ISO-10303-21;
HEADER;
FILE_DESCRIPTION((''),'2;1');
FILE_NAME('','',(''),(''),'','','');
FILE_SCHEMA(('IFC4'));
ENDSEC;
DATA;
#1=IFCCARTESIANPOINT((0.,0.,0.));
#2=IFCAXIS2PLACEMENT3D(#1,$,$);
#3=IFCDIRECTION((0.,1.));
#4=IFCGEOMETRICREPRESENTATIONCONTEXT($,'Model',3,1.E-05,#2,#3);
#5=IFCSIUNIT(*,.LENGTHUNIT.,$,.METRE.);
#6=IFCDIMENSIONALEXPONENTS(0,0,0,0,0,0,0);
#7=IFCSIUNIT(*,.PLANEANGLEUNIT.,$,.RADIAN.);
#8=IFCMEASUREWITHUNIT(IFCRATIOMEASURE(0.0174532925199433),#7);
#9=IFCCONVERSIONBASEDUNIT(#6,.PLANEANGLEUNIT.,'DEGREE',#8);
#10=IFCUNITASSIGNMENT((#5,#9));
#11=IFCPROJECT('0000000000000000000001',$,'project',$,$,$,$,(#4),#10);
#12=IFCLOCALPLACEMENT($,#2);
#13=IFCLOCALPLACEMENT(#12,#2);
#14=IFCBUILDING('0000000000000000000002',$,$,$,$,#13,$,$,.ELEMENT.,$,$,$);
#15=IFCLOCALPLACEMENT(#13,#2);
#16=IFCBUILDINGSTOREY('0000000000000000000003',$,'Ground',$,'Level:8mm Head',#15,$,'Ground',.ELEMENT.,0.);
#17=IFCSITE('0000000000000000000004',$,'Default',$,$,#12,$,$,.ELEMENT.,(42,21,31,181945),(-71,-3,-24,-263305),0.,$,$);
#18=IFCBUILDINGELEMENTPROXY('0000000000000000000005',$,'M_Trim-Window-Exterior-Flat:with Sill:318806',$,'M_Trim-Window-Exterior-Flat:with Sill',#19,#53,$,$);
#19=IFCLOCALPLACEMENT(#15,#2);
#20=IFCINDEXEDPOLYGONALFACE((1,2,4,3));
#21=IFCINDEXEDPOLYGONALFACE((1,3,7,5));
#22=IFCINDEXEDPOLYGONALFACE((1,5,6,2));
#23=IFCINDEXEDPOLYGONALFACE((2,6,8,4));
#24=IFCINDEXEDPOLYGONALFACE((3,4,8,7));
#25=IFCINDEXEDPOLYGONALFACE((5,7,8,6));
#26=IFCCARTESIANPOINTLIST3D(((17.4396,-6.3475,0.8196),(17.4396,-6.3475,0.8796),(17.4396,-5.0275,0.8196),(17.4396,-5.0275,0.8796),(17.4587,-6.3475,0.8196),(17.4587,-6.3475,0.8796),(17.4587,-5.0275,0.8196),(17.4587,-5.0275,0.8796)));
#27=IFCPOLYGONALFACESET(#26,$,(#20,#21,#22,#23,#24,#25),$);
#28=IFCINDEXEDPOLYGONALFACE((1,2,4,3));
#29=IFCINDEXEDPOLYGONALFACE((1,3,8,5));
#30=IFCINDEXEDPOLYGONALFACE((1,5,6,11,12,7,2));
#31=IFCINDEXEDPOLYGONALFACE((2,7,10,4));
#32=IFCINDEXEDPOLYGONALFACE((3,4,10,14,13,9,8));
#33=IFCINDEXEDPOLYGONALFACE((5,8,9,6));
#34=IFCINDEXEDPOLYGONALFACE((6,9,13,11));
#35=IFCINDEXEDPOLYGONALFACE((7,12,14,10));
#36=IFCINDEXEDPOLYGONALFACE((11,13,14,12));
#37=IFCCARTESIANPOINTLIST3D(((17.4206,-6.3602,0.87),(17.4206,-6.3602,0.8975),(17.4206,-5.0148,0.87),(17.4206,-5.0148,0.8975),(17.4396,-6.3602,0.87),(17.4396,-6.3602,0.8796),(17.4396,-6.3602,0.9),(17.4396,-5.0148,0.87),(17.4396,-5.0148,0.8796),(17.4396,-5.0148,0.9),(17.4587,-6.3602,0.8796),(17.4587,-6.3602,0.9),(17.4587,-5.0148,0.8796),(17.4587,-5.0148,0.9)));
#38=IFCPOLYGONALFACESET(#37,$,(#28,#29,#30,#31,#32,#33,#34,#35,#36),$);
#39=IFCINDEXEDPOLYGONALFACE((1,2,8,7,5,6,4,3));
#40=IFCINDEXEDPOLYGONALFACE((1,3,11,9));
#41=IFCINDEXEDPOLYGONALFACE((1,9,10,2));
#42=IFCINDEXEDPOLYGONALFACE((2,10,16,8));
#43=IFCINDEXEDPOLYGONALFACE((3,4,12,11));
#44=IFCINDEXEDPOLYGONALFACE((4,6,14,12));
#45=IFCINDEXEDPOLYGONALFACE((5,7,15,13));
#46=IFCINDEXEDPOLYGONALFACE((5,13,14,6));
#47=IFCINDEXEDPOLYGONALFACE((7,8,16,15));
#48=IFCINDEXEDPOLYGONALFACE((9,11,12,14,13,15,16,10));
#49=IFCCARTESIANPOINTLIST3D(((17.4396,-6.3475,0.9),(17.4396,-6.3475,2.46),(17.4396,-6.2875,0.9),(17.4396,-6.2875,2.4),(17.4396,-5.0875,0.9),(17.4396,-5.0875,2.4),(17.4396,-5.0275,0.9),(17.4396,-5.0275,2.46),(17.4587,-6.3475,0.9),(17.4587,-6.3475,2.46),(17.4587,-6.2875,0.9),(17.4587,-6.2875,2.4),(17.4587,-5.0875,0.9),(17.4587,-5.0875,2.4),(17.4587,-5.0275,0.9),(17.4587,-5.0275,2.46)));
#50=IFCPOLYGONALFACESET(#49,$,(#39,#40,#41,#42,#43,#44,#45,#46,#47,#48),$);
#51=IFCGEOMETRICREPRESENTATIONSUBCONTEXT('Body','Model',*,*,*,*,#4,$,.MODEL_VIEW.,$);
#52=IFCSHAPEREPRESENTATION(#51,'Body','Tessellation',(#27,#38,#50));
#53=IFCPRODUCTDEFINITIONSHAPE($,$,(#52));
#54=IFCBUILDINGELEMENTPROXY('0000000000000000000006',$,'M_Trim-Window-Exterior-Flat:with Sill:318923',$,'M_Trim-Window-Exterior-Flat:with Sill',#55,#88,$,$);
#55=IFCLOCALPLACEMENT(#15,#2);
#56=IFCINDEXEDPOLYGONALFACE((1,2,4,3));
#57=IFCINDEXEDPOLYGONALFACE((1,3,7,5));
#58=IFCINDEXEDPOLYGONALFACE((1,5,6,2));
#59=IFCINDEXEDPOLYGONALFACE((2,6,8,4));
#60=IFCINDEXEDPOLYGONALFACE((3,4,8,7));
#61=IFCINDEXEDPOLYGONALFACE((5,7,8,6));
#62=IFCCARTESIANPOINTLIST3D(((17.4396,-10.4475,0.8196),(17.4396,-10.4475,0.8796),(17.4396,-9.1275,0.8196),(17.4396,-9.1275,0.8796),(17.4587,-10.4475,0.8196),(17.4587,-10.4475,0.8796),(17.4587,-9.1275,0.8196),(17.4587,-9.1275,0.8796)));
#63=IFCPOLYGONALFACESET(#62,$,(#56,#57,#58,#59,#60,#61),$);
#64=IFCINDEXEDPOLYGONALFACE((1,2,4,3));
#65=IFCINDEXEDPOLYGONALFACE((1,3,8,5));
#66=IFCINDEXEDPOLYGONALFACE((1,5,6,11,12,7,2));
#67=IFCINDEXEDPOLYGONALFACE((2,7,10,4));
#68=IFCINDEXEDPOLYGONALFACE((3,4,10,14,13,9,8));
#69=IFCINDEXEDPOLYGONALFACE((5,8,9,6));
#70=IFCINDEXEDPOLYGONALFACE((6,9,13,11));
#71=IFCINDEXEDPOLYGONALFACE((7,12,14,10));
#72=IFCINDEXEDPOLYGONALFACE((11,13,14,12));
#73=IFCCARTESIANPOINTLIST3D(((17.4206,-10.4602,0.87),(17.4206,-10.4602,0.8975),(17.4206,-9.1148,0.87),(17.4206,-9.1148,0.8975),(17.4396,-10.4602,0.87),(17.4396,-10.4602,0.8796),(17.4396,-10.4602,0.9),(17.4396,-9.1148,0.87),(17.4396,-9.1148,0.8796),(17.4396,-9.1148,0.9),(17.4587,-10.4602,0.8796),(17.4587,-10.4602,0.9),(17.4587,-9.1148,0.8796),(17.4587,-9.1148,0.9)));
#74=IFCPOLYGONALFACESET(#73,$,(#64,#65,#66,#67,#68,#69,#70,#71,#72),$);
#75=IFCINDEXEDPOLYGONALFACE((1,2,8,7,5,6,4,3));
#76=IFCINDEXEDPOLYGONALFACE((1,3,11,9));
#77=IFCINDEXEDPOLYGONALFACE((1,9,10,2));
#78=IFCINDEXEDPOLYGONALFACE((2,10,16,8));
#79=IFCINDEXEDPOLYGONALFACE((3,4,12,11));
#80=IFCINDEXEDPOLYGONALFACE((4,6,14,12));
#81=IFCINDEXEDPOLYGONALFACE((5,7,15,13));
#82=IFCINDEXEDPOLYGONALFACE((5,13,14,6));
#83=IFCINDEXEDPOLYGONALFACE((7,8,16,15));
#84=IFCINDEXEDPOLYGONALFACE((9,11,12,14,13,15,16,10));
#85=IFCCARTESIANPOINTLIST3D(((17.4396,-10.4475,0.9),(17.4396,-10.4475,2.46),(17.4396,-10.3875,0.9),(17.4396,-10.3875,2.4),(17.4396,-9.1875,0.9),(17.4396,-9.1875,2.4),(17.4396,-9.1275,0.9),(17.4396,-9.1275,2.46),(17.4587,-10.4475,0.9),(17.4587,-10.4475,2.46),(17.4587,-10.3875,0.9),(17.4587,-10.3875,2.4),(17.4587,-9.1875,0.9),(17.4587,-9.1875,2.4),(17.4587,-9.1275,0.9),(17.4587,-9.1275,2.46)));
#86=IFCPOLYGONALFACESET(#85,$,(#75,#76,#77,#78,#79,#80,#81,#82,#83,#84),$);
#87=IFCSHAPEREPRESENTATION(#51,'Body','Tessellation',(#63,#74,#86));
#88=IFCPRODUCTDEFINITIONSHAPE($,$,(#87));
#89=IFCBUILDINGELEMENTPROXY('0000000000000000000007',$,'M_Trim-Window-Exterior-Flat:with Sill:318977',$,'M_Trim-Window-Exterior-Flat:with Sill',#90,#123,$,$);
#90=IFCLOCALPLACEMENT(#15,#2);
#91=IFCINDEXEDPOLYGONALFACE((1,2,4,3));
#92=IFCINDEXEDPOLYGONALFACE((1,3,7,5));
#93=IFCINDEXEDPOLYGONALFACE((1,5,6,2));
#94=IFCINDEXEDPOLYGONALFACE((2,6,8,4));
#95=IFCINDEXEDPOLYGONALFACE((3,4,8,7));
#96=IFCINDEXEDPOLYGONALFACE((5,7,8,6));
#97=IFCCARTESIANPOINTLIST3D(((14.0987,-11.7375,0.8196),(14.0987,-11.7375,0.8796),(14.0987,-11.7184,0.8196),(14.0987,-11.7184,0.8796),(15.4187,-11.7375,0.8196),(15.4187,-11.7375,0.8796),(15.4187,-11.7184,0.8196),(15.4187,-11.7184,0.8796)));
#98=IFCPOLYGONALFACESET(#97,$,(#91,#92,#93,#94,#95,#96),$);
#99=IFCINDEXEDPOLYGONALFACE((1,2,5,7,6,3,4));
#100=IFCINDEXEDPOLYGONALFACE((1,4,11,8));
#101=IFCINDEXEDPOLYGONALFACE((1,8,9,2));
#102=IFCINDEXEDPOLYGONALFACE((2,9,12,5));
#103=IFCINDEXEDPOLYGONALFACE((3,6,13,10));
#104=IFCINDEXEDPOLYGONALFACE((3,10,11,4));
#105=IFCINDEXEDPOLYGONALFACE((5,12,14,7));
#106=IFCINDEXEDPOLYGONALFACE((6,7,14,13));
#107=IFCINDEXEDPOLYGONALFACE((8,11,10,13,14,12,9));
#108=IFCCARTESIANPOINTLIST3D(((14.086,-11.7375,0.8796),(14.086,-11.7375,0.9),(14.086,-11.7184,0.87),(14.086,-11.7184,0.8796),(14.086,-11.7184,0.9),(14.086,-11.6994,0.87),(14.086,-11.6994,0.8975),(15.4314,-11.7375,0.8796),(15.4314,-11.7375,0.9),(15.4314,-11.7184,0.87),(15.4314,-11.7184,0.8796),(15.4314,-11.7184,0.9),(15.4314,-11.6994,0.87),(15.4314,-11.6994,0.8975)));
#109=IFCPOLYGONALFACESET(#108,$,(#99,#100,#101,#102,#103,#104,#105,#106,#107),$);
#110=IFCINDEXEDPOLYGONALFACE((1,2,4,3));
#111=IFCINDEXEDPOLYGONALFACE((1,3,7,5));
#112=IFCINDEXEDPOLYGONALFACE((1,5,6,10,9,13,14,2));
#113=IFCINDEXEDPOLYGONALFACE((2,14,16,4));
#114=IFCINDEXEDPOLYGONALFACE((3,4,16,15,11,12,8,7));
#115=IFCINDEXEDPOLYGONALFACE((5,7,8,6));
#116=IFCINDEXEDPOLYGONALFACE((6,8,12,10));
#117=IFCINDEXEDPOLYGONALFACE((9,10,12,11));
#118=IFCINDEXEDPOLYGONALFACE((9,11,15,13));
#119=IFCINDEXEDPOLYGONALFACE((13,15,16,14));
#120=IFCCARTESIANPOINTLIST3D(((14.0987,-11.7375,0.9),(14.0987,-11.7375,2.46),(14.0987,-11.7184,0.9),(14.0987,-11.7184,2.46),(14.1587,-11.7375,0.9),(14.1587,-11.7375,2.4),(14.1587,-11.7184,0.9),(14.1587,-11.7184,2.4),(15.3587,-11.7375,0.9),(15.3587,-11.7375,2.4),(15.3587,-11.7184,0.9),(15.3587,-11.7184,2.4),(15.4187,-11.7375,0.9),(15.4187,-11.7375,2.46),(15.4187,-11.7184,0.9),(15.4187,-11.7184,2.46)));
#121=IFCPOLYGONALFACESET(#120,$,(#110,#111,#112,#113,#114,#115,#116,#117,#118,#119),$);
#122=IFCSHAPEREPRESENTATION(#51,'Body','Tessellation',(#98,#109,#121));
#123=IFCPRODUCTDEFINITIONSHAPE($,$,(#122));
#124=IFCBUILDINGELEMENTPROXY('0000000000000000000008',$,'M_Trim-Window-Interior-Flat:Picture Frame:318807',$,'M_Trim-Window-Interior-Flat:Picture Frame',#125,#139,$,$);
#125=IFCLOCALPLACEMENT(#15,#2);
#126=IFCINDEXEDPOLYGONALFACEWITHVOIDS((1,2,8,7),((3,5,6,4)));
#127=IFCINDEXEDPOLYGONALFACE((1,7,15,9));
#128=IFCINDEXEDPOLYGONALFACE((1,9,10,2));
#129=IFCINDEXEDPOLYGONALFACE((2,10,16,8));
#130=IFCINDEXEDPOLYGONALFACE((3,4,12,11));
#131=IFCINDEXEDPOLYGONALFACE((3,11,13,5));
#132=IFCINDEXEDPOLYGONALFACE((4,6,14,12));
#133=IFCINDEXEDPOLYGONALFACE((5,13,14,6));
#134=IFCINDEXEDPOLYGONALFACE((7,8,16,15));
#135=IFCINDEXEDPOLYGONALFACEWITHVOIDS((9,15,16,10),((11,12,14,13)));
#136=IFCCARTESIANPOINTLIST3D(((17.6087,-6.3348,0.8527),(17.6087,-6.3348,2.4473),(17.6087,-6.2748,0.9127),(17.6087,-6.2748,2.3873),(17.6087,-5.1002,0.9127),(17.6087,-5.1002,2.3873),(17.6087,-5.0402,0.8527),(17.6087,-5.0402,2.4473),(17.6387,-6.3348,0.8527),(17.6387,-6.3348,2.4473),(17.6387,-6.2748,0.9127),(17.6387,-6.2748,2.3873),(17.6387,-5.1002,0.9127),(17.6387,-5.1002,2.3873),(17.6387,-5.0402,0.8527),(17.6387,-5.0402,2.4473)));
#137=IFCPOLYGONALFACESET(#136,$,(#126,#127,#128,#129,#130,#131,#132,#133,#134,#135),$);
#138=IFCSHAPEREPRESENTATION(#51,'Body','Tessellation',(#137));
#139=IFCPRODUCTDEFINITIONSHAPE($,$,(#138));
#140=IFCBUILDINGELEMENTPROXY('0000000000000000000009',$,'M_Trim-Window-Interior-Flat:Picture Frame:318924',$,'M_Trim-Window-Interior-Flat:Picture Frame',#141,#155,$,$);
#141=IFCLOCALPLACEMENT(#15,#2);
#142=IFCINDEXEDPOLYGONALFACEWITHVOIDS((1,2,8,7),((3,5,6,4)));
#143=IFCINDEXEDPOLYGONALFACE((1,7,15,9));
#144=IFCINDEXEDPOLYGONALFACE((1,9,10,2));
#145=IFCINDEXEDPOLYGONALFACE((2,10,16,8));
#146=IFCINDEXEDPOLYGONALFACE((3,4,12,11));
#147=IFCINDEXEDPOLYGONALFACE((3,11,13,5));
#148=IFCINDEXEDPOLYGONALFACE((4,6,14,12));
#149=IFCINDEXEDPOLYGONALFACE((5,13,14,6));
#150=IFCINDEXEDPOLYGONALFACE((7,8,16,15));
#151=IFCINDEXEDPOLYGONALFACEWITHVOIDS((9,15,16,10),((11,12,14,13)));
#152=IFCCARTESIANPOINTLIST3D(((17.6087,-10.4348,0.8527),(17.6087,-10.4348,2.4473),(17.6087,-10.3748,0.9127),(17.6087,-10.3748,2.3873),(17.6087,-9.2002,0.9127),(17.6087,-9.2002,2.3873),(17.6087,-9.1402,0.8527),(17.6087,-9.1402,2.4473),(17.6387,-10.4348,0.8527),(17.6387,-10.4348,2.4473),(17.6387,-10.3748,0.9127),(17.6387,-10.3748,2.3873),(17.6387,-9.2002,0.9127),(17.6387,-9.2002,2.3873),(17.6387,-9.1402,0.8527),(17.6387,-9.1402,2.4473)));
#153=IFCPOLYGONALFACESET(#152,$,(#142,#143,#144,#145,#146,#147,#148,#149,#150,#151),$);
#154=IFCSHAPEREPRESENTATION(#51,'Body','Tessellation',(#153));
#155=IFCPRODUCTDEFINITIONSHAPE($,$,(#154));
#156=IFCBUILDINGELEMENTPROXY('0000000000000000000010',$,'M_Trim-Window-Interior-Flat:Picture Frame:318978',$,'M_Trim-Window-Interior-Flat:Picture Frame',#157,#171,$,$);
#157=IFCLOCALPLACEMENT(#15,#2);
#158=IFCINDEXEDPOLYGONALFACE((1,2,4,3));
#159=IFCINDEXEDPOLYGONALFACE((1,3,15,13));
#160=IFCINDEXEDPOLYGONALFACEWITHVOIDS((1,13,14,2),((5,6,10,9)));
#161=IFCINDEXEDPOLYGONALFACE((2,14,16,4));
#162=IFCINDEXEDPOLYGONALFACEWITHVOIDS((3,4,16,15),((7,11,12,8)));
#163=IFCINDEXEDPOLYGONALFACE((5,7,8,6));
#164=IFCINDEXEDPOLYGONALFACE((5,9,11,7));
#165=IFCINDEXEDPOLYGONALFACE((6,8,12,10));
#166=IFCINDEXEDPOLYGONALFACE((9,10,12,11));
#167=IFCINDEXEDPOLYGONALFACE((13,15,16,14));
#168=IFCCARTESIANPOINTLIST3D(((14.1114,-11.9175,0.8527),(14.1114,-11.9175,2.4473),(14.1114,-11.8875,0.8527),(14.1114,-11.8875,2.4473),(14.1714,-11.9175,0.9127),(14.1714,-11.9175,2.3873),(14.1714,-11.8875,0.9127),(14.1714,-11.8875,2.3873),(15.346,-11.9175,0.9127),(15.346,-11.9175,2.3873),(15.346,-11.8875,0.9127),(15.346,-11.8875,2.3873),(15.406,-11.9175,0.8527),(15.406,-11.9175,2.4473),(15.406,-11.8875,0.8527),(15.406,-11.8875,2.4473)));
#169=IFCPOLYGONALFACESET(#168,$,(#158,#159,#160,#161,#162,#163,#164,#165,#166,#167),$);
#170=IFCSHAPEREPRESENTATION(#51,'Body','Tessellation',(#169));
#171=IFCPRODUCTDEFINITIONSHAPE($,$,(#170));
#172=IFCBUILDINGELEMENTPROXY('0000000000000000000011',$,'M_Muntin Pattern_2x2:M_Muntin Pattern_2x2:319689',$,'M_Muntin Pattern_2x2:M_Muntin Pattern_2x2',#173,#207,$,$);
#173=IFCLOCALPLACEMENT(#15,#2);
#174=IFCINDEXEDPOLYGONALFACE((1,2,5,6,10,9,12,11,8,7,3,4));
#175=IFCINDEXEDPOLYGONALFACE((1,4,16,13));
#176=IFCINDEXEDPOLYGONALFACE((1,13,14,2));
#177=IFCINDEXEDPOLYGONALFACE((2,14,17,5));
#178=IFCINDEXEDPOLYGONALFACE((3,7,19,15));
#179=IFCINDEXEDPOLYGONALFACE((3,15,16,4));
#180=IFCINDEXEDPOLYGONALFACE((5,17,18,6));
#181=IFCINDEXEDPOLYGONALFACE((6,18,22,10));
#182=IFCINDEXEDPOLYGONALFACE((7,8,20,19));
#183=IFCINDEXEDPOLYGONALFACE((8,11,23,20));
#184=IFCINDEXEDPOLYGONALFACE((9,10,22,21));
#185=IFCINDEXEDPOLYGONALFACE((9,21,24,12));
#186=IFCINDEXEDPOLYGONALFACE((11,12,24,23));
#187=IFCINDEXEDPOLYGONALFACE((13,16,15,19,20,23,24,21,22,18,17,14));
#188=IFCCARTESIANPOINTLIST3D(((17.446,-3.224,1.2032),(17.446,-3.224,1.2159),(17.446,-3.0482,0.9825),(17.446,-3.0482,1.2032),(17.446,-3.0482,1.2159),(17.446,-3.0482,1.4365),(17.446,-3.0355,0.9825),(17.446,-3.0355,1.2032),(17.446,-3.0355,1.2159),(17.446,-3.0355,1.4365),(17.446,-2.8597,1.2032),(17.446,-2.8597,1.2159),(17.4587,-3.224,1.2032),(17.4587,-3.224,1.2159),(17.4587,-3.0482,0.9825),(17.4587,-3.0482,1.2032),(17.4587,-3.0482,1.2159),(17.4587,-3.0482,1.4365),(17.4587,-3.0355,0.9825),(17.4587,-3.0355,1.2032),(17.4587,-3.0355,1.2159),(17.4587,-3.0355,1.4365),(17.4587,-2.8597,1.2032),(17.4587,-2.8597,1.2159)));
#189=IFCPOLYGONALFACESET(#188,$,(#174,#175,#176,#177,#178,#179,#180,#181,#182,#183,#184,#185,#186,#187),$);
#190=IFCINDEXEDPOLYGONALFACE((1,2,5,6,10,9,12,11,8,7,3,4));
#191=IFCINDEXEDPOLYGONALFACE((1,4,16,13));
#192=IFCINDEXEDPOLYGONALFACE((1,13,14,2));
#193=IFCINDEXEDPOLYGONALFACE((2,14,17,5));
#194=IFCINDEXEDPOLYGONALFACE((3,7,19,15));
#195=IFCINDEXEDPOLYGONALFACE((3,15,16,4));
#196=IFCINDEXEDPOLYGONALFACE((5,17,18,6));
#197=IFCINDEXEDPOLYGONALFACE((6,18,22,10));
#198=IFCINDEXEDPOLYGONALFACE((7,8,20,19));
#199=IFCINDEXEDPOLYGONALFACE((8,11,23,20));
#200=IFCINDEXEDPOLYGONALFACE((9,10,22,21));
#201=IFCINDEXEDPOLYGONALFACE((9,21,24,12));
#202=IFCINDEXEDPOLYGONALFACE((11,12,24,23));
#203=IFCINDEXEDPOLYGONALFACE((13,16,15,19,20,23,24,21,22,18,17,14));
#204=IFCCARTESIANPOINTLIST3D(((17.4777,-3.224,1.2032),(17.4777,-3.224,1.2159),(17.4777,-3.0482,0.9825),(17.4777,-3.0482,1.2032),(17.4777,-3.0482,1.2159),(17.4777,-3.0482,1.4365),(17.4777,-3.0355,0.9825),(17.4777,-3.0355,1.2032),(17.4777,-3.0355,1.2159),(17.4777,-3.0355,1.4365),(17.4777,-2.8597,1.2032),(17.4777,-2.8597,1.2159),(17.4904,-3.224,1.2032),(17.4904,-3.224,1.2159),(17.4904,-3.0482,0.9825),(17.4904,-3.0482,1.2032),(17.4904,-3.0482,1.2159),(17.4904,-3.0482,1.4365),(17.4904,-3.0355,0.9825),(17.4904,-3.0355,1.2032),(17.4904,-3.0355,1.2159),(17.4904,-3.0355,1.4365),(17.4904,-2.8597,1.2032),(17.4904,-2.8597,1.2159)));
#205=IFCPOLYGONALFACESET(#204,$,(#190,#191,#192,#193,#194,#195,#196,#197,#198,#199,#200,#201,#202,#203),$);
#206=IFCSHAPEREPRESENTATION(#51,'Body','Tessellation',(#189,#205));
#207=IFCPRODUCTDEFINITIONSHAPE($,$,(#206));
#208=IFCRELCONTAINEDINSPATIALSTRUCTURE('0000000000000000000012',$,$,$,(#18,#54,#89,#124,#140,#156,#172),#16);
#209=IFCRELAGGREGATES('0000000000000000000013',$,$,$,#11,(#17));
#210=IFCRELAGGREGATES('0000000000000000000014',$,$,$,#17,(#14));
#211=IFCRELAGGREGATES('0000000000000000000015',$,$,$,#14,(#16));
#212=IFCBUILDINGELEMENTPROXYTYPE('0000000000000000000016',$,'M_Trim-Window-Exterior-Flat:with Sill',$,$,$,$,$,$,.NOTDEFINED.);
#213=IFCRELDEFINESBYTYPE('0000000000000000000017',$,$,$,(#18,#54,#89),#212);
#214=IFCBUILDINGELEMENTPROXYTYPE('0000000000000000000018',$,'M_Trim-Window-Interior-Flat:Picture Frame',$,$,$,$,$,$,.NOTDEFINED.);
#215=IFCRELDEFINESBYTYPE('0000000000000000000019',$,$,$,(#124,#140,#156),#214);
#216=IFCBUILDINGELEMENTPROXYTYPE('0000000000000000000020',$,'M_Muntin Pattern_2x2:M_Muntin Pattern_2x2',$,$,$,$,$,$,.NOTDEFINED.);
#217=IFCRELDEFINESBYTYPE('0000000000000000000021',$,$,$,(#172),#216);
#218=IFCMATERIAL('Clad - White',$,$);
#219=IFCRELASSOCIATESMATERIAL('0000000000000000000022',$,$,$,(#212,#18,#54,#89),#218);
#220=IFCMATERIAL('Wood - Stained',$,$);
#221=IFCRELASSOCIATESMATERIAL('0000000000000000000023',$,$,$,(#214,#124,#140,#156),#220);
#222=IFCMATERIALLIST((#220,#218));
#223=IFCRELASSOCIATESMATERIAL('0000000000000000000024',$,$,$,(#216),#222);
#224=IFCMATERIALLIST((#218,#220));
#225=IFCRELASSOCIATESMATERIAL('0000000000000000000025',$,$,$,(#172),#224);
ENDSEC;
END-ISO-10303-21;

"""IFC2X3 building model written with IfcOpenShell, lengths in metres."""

from ifc_helpers import new_model, entity, si_unit, converted_unit, direction, frame, frame_2d, origin, place, context, subcontext, project, spatial, polyline, rectangle, outline, extrude, source, transform, mapped, material, material_list, type_object, type_shapes, element, save


model = new_model("IFC2X3")

# Units and contexts
model_context = context("Model", 3, precision=1e-05, world=origin(), true_north=direction((0.0, 1.0)))
body_context = subcontext(model_context, "Body", "Model", "MODEL_VIEW")
ifc_project = project(units=[si_unit("LENGTHUNIT", "METRE"), converted_unit("PLANEANGLEUNIT", "DEGREE", entity("IfcRatioMeasure", 0.0174532925199433), si_unit("PLANEANGLEUNIT", "RADIAN"), dimensions=[0, 0, 0, 0, 0, 0, 0])], contexts=[model_context])

# Site, building, storey
site_placement = place(None, origin())
site = spatial("IfcSite", under=ifc_project, at=site_placement, Name="Default", CompositionType="ELEMENT", RefLatitude=(42, 21, 31, 181945), RefLongitude=(-71, -3, -24, -263305), RefElevation=0.0)
building_placement = place(site_placement, origin())
building = spatial("IfcBuilding", under=site, at=building_placement, CompositionType="ELEMENT")
storey_placement = place(building_placement, origin())
storey = spatial("IfcBuildingStorey", under=building, at=storey_placement, Name="Ground", ObjectType="Level:8mm Head", LongName="Ground", CompositionType="ELEMENT", Elevation=0.0)

# Building element proxies
ifc_material_1 = material(Name="Clad - White")
ifc_material_2 = material(Name="Wood - Stained")
building_element_proxy_type_1 = type_object("IfcBuildingElementProxyType", Name="M_Trim-Window-Exterior-Flat:with Sill", PredefinedType="NOTDEFINED", material=ifc_material_1)
shared_shape_1 = source(origin(), body_context, "Body", "SweptSolid", [
    extrude(rectangle(XDim=1.32, YDim=0.06, at=frame_2d((0.0, 0.0), x_axis=(1.0, 0.0))), frame((0.0, -1.5504, 0.0), z_axis=(0.0, 0.0, 1.0), x_axis=(-1.0, 0.0, 0.0)), (0.0, 0.0, 1.0), 0.0191),
    extrude(outline(polyline([(-0.019, -0.0152), (0.0, -0.0152), (0.0, -0.0057), (0.019, -0.0057), (0.019, 0.0148), (0.0, 0.0148), (-0.019, 0.0123), (-0.019, -0.0152)])), frame((-0.6727, -1.5148, 0.019), z_axis=(1.0, 0.0, 0.0), x_axis=(0.0, 0.0, -1.0)), (0.0, 0.0, 1.0), 1.3454),
    extrude(outline(polyline([(-0.795, -0.66), (0.765, -0.66), (0.765, -0.6), (-0.735, -0.6), (-0.735, 0.6), (0.765, 0.6), (0.765, 0.66), (-0.795, 0.66), (-0.795, -0.66)])), frame((0.0, -0.735, 0.0), z_axis=(0.0, 0.0, 1.0), x_axis=(0.0, -1.0, 0.0)), (0.0, 0.0, 1.0), 0.0191),
])
type_shapes(building_element_proxy_type_1, [shared_shape_1])
for number, where, z_axis, x_axis, name in (
    (1, (17.4587, -5.6875, 2.4), (-1.0, 0.0, 0.0), (0.0, -1.0, 0.0), "M_Trim-Window-Exterior-Flat:with Sill:318806"),
    (2, (17.4587, -9.7875, 2.4), (-1.0, 0.0, 0.0), (0.0, -1.0, 0.0), "M_Trim-Window-Exterior-Flat:with Sill:318923"),
    (3, (14.7587, -11.7375, 2.4), (0.0, 1.0, 0.0), (-1.0, 0.0, 0.0), "M_Trim-Window-Exterior-Flat:with Sill:318977"),
):
    element("IfcBuildingElementProxy", number, at=place(storey_placement, frame(where, z_axis=z_axis, x_axis=x_axis)), inside=storey, type_object=building_element_proxy_type_1, material=ifc_material_1, Name=name, ObjectType="M_Trim-Window-Exterior-Flat:with Sill", context=body_context, shape_type="MappedRepresentation", body=[
        mapped(shared_shape_1, transform((0.0, 0.0, 0.0), scale=1.0)),
    ])
building_element_proxy_type_2 = type_object("IfcBuildingElementProxyType", Name="M_Trim-Window-Interior-Flat:Picture Frame", PredefinedType="NOTDEFINED", material=ifc_material_2)
shared_shape_2 = source(origin(), body_context, "Body", "SweptSolid", [
    extrude(outline(polyline([(-0.6473, -0.7973), (0.6473, -0.7973), (0.6473, 0.7973), (-0.6473, 0.7973), (-0.6473, -0.7973)]), holes=[polyline([(-0.5873, -0.7373), (-0.5873, 0.7373), (0.5873, 0.7373), (0.5873, -0.7373), (-0.5873, -0.7373)])]), frame((0.0, -0.75, 0.0), z_axis=(0.0, 0.0, 1.0), x_axis=(-1.0, 0.0, 0.0)), (0.0, 0.0, 1.0), 0.03),
])
type_shapes(building_element_proxy_type_2, [shared_shape_2])
for number, where, z_axis, x_axis, name in (
    (4, (17.6087, -5.6875, 2.4), (1.0, 0.0, 0.0), (0.0, 1.0, 0.0), "M_Trim-Window-Interior-Flat:Picture Frame:318807"),
    (5, (17.6087, -9.7875, 2.4), (1.0, 0.0, 0.0), (0.0, 1.0, 0.0), "M_Trim-Window-Interior-Flat:Picture Frame:318924"),
    (6, (14.7587, -11.8875, 2.4), (0.0, -1.0, 0.0), (1.0, 0.0, 0.0), "M_Trim-Window-Interior-Flat:Picture Frame:318978"),
):
    element("IfcBuildingElementProxy", number, at=place(storey_placement, frame(where, z_axis=z_axis, x_axis=x_axis)), inside=storey, type_object=building_element_proxy_type_2, material=ifc_material_2, Name=name, ObjectType="M_Trim-Window-Interior-Flat:Picture Frame", context=body_context, shape_type="MappedRepresentation", body=[
        mapped(shared_shape_2, transform((0.0, 0.0, 0.0), scale=1.0)),
    ])
ifc_material_list_1 = material_list([ifc_material_1, ifc_material_2])
ifc_material_list_2 = material_list([ifc_material_2, ifc_material_1])
building_element_proxy_type_3 = type_object("IfcBuildingElementProxyType", Name="M_Muntin Pattern_2x2:M_Muntin Pattern_2x2", PredefinedType="NOTDEFINED", material=ifc_material_list_2)
shared_shape_3 = source(origin(), body_context, "Body", "SweptSolid", [
    extrude(outline(polyline([(0.0064, -0.0064), (0.227, -0.0064), (0.227, 0.0063), (0.0064, 0.0063), (0.0064, 0.1821), (-0.0063, 0.1821), (-0.0063, 0.0063), (-0.227, 0.0063), (-0.227, -0.0064), (-0.0063, -0.0064), (-0.0063, -0.1821), (0.0064, -0.1821), (0.0064, -0.0064)])), frame((0.0, 0.0095, 0.227), z_axis=(0.0, 1.0, 0.0), x_axis=(0.0, 0.0, 1.0)), (0.0, 0.0, 1.0), 0.0127),
    extrude(outline(polyline([(0.0064, -0.0064), (0.227, -0.0064), (0.227, 0.0063), (0.0064, 0.0063), (0.0064, 0.1821), (-0.0063, 0.1821), (-0.0063, 0.0063), (-0.227, 0.0063), (-0.227, -0.0064), (-0.0063, -0.0064), (-0.0063, -0.1821), (0.0064, -0.1821), (0.0064, -0.0064)])), frame((0.0, -0.0222, 0.227), z_axis=(0.0, 1.0, 0.0), x_axis=(0.0, 0.0, 1.0)), (0.0, 0.0, 1.0), 0.0127),
])
type_shapes(building_element_proxy_type_3, [shared_shape_3])
proxy_1_placement = place(storey_placement, frame((17.4682, -3.0418, 0.9825), z_axis=(0.0, 0.0, 1.0), x_axis=(0.0, 1.0, 0.0)))
element("IfcBuildingElementProxy", 7, at=proxy_1_placement, inside=storey, type_object=building_element_proxy_type_3, material=ifc_material_list_1, Name="M_Muntin Pattern_2x2:M_Muntin Pattern_2x2:319689", ObjectType="M_Muntin Pattern_2x2:M_Muntin Pattern_2x2", context=body_context, shape_type="MappedRepresentation", body=[
    mapped(shared_shape_3, transform((0.0, 0.0, 0.0), scale=1.0)),
])

save(model, "model.ifc")
